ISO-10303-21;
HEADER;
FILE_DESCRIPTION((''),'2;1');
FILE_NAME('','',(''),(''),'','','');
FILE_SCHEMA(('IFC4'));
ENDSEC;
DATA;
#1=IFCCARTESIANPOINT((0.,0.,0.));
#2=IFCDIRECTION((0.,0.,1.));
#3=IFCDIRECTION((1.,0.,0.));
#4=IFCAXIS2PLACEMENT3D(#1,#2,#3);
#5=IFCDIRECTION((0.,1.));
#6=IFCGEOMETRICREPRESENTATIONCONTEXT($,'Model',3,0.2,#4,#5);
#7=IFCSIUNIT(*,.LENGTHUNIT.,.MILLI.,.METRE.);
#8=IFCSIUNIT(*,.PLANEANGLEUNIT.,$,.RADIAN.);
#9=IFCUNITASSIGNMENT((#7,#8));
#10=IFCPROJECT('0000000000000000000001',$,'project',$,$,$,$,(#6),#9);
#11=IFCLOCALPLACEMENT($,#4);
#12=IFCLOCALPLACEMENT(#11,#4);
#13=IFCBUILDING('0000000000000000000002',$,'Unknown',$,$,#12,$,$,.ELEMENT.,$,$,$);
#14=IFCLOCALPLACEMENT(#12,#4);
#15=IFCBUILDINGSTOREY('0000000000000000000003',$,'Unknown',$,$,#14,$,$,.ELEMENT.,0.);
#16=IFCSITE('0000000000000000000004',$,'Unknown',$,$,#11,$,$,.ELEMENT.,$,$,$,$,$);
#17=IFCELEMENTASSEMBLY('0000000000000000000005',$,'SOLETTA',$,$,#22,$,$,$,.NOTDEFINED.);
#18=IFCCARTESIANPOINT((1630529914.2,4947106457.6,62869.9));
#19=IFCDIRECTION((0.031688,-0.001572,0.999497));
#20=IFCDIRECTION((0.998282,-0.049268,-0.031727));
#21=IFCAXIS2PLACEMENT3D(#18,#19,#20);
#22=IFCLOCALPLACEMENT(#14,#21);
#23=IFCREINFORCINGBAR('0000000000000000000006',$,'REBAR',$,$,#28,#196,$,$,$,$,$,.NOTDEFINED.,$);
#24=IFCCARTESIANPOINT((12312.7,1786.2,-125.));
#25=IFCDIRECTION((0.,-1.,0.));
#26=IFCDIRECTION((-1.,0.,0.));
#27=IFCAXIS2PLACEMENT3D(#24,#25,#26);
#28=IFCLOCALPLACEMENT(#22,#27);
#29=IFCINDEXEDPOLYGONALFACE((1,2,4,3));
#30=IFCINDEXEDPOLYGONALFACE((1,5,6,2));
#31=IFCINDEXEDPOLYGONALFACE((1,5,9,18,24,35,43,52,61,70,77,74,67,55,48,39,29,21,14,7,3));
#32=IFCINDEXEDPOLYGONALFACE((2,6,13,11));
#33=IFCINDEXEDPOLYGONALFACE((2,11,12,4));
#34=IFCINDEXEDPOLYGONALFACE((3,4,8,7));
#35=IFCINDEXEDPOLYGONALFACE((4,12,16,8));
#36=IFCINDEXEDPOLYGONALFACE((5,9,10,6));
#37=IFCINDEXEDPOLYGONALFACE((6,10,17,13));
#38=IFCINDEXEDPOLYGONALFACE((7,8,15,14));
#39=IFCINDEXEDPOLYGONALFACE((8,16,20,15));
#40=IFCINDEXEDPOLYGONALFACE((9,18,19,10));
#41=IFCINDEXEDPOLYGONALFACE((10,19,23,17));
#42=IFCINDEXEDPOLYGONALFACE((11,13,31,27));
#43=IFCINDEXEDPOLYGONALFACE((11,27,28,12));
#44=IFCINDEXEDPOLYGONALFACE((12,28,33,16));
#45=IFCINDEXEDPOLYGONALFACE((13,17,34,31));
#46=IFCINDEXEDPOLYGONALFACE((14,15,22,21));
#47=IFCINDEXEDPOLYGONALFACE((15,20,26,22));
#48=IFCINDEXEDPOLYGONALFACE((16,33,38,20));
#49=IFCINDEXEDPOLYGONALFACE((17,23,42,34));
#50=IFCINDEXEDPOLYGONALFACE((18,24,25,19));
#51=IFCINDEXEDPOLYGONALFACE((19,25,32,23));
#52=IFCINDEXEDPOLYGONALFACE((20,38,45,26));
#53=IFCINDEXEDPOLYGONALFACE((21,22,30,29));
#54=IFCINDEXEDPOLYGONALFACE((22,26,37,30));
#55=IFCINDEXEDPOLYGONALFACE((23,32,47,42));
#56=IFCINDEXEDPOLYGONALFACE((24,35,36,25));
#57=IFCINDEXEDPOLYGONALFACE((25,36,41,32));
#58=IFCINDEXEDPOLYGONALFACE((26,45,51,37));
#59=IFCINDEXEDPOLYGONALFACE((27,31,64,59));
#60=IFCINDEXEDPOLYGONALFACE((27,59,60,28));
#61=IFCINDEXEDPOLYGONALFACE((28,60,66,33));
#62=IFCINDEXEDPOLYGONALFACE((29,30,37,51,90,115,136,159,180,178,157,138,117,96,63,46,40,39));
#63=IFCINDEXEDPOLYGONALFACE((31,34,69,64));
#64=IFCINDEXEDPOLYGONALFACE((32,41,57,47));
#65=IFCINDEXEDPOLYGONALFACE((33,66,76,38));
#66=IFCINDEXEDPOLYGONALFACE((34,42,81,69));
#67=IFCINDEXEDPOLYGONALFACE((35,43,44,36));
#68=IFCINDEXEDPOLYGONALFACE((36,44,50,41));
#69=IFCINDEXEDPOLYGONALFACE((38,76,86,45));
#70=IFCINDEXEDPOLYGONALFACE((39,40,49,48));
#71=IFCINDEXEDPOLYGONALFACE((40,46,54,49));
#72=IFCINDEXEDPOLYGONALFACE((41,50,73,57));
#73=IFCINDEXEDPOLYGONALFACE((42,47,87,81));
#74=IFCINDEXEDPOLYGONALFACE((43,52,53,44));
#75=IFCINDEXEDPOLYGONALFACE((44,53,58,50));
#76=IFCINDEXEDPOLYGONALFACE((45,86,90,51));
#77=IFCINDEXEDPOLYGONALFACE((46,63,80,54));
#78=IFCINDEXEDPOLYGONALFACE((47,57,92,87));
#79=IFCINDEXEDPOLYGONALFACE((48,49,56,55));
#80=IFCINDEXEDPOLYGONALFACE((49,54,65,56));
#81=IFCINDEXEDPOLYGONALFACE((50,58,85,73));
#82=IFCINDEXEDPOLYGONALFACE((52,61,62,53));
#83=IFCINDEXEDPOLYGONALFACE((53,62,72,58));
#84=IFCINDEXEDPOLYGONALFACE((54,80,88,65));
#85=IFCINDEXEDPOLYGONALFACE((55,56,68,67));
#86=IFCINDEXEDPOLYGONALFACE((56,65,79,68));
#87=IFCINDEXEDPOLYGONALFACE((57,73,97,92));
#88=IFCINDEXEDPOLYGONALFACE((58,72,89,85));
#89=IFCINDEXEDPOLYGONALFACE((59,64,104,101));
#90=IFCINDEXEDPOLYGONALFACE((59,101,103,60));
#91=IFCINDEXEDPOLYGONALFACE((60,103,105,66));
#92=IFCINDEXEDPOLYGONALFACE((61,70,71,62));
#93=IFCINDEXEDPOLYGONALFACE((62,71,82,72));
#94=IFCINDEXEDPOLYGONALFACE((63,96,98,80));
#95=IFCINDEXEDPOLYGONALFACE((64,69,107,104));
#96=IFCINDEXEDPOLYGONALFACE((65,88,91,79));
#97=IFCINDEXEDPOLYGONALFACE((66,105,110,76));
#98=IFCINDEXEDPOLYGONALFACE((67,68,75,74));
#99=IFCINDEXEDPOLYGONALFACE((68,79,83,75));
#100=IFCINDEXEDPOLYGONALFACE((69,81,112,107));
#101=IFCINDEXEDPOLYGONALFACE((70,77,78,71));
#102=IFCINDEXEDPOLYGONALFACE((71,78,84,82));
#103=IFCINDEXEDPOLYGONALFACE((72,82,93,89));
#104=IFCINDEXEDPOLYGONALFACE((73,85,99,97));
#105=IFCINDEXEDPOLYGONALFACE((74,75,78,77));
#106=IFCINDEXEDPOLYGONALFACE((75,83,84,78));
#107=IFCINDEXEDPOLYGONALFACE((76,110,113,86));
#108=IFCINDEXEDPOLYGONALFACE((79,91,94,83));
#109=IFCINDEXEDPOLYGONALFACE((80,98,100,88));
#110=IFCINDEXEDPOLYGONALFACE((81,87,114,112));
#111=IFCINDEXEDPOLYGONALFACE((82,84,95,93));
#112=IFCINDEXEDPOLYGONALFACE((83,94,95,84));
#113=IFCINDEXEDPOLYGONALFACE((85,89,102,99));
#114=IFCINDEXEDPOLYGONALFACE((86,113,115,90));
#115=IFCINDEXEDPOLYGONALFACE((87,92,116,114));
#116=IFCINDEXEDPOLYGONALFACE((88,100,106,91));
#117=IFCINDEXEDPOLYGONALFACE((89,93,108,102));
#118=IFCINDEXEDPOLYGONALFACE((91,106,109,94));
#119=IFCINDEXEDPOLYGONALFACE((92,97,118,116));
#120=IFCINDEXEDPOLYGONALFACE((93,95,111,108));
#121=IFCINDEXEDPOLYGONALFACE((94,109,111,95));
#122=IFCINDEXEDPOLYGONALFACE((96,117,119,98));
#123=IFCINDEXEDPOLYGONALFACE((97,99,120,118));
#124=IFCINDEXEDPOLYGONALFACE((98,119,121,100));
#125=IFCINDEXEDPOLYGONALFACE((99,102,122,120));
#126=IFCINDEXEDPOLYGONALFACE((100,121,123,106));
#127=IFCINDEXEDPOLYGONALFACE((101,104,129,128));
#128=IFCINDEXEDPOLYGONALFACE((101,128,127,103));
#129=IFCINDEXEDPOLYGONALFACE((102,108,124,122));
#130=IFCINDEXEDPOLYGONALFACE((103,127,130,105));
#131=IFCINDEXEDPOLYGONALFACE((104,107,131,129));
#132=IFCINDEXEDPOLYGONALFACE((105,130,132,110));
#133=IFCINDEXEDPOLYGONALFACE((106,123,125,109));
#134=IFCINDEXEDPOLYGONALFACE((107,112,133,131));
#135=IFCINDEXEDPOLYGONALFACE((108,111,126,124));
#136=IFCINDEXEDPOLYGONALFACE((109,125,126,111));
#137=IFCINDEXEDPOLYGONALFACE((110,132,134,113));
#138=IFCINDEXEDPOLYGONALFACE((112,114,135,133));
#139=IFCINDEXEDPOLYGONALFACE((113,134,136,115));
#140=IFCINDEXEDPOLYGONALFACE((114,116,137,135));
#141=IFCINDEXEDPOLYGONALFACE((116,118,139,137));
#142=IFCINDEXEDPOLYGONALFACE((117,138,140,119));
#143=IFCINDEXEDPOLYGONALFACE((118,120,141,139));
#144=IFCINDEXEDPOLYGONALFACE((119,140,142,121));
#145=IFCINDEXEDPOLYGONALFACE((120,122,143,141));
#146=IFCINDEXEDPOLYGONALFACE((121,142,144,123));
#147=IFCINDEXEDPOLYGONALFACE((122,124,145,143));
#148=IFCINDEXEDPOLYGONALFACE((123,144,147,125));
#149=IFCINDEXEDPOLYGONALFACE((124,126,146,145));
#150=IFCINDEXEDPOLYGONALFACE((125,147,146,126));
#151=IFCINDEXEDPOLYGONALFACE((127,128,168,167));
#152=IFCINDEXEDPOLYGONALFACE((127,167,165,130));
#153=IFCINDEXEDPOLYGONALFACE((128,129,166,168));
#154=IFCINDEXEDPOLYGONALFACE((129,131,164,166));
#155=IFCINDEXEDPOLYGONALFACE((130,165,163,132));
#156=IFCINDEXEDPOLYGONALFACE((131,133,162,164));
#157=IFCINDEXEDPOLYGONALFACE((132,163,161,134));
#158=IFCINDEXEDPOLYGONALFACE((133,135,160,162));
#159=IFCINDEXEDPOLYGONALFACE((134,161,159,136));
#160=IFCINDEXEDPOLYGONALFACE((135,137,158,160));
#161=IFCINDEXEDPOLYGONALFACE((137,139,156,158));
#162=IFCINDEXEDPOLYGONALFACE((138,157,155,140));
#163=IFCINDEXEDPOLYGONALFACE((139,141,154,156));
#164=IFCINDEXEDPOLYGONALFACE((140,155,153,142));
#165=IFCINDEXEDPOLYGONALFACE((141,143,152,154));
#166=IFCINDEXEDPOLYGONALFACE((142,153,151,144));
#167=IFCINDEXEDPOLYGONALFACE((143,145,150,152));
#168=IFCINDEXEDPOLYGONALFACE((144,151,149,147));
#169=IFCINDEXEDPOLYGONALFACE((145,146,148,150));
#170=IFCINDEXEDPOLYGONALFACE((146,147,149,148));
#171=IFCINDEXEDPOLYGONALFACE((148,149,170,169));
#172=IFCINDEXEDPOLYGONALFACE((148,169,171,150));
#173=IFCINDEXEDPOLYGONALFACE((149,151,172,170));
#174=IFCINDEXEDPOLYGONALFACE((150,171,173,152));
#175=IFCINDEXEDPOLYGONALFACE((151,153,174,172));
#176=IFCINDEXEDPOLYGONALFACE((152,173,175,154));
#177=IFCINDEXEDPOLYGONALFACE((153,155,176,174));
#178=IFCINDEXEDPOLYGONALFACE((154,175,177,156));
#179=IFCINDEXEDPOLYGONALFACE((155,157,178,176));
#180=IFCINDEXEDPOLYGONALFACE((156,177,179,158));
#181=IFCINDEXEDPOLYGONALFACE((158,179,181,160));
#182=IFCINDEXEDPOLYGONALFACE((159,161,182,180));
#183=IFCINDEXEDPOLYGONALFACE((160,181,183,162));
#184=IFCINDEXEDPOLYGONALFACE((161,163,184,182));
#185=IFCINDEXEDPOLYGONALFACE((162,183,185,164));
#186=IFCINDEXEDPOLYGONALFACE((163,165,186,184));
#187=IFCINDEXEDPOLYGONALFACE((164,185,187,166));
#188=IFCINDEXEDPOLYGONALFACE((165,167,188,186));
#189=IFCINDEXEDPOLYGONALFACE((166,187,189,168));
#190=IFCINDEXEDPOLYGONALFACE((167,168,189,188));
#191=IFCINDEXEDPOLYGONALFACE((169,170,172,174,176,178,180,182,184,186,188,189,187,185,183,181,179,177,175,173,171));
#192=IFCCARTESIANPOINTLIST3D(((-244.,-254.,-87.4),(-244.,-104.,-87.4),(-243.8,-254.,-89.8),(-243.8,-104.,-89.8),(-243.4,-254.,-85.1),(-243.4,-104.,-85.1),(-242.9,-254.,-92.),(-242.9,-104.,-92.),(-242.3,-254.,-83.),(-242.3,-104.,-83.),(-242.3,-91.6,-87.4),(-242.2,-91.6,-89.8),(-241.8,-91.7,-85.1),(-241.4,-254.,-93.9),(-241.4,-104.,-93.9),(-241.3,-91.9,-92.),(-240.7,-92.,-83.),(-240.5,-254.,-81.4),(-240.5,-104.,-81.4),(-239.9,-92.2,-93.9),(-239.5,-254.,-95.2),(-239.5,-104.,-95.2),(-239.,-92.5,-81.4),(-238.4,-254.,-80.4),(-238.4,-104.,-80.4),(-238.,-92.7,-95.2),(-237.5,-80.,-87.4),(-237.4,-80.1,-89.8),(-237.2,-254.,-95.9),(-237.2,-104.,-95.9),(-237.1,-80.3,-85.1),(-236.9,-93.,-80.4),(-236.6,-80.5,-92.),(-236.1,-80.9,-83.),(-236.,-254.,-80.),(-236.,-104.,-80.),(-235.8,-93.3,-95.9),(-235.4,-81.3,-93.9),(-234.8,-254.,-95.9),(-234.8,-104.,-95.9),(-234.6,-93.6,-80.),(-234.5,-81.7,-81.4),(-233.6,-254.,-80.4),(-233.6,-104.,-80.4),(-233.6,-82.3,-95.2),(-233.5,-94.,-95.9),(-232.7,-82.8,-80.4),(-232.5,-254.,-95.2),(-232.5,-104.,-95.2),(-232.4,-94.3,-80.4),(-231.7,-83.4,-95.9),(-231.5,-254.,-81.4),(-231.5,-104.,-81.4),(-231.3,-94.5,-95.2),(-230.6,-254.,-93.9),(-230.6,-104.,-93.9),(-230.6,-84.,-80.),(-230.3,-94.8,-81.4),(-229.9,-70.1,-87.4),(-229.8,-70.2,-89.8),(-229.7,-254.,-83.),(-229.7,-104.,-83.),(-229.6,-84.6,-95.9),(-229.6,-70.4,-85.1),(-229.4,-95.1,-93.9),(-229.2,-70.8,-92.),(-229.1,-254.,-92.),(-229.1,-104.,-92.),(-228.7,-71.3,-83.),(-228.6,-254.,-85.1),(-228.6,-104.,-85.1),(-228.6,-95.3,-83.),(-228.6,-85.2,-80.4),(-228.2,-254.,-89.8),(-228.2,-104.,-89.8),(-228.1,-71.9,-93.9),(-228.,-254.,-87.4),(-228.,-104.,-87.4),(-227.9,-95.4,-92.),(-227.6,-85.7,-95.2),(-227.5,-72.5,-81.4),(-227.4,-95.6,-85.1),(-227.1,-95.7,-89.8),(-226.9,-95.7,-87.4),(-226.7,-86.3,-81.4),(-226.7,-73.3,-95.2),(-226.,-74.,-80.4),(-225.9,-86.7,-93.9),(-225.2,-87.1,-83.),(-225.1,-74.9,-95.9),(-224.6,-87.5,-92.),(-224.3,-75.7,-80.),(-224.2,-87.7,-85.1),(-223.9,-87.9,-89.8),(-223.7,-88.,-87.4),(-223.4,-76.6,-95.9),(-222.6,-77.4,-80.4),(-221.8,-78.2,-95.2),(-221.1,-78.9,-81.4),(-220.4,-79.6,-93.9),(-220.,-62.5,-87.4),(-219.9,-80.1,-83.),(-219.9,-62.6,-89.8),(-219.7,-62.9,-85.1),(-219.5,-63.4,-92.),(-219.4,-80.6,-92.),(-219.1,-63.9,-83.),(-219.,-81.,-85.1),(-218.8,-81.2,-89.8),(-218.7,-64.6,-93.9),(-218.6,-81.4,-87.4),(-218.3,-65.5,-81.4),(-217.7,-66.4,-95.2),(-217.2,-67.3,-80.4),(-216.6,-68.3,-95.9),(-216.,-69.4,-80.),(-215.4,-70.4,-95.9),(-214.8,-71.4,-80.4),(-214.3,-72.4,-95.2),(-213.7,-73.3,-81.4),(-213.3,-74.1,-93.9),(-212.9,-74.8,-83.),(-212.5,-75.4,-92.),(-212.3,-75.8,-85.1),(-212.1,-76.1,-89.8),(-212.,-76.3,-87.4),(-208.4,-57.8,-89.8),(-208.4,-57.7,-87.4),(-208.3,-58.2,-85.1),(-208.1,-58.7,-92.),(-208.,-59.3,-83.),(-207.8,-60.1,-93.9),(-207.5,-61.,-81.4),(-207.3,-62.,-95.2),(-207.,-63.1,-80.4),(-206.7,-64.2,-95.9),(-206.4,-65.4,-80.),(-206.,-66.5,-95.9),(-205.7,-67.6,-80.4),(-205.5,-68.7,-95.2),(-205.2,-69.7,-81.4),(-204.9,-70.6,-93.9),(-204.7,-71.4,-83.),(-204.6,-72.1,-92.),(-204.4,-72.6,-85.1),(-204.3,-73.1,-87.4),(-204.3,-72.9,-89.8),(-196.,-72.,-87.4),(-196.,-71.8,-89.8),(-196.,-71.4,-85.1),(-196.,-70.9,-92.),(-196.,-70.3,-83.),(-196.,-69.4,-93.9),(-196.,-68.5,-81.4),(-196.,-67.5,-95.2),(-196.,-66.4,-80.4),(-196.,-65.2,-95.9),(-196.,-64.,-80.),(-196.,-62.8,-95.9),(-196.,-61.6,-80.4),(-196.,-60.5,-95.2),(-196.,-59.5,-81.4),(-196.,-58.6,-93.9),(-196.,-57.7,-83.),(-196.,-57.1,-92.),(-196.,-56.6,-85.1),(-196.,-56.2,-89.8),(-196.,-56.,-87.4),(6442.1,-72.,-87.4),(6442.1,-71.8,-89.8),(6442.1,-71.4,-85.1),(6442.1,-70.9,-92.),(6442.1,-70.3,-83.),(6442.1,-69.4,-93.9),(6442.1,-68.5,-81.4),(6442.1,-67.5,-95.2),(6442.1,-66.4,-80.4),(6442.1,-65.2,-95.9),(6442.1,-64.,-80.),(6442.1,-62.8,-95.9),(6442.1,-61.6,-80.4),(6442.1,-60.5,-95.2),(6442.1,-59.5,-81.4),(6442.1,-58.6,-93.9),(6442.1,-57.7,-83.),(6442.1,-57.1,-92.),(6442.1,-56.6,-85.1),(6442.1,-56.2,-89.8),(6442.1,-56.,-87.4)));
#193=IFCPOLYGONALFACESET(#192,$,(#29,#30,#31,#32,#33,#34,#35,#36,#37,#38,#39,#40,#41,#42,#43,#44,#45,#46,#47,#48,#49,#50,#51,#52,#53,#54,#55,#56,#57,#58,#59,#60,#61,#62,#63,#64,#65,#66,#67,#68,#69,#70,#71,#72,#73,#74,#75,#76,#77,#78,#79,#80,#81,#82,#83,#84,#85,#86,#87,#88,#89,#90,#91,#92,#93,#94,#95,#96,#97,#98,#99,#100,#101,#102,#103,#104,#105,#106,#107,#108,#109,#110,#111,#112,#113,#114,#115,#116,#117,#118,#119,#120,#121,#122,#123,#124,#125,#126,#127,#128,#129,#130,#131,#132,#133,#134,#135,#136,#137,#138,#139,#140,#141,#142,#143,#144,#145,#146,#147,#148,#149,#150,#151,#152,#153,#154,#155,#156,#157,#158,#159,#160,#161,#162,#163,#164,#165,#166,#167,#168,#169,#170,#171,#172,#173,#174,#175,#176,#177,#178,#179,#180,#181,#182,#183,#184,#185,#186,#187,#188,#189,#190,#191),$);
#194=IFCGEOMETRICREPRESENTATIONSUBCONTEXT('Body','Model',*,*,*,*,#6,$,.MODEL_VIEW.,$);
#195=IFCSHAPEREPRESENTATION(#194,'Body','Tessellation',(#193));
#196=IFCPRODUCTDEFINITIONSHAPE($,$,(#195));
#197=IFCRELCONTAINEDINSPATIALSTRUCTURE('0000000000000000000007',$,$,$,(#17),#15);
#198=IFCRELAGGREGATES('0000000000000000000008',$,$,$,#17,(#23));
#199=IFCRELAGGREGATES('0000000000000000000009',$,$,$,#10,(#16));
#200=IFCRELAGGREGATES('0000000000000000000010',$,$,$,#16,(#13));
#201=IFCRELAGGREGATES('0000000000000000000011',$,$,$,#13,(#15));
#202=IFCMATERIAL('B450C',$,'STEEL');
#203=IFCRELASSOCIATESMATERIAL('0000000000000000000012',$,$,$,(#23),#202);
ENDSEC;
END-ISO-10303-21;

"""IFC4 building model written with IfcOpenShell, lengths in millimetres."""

from ifc_helpers import new_model, entity, si_unit, direction, frame, origin_with_axes, place, context, subcontext, project, spatial, material, element, aggregate, save


model = new_model("IFC4")

# Units and contexts
model_context = context("Model", 3, precision=0.2, world=origin_with_axes(), true_north=direction((0.0, 1.0)))
body_context = subcontext(model_context, "Body", "Model", "MODEL_VIEW")
ifc_project = project(units=[si_unit("LENGTHUNIT", "METRE", prefix="MILLI"), si_unit("PLANEANGLEUNIT", "RADIAN")], contexts=[model_context])

# Site, building, storey
site_placement = place(None, origin_with_axes())
site = spatial("IfcSite", under=ifc_project, at=site_placement, Name="Unknown", CompositionType="ELEMENT")
building_placement = place(site_placement, origin_with_axes())
building = spatial("IfcBuilding", under=site, at=building_placement, Name="Unknown", CompositionType="ELEMENT")
storey_placement = place(building_placement, origin_with_axes())
storey = spatial("IfcBuildingStorey", under=building, at=storey_placement, Name="Unknown", CompositionType="ELEMENT", Elevation=0.0)

# Shared definitions
ifc_material = material(Name="B450C", Category="STEEL")

# Element assembly, reinforcing bar
assembly_1_placement = place(storey_placement, frame((1630529914.2, 4947106457.6, 62869.9), z_axis=(0.031688, -0.001572, 0.999497), x_axis=(0.998282, -0.049268, -0.031727)))
assembly_1 = element("IfcElementAssembly", 1, at=assembly_1_placement, inside=storey, Name="SOLETTA", PredefinedType="NOTDEFINED")
reinforcing_bar_1_placement = place(assembly_1_placement, frame((12312.7, 1786.2, -125.0), z_axis=(0.0, -1.0, 0.0), x_axis=(-1.0, 0.0, 0.0)))
reinforcing_bar_1 = element("IfcReinforcingBar", 2, at=reinforcing_bar_1_placement, material=ifc_material, Name="REBAR", PredefinedType="NOTDEFINED", context=body_context, shape_type="AdvancedSweptSolid", body=[
    entity("IfcSweptDiskSolid", entity("IfcIndexedPolyCurve", entity("IfcCartesianPointList3D", [[-236.0, -254.0, -88.0], [-236.0, -104.0, -88.0], [-224.3, -75.7, -88.0], [-196.0, -64.0, -88.0], [6442.1, -64.0, -88.0]]), [entity("IfcLineIndex", [1, 2]), entity("IfcArcIndex", [2, 3, 4]), entity("IfcLineIndex", [4, 5])]), 8.0),
])
aggregate(assembly_1, [reinforcing_bar_1])

save(model, "model.ifc")
